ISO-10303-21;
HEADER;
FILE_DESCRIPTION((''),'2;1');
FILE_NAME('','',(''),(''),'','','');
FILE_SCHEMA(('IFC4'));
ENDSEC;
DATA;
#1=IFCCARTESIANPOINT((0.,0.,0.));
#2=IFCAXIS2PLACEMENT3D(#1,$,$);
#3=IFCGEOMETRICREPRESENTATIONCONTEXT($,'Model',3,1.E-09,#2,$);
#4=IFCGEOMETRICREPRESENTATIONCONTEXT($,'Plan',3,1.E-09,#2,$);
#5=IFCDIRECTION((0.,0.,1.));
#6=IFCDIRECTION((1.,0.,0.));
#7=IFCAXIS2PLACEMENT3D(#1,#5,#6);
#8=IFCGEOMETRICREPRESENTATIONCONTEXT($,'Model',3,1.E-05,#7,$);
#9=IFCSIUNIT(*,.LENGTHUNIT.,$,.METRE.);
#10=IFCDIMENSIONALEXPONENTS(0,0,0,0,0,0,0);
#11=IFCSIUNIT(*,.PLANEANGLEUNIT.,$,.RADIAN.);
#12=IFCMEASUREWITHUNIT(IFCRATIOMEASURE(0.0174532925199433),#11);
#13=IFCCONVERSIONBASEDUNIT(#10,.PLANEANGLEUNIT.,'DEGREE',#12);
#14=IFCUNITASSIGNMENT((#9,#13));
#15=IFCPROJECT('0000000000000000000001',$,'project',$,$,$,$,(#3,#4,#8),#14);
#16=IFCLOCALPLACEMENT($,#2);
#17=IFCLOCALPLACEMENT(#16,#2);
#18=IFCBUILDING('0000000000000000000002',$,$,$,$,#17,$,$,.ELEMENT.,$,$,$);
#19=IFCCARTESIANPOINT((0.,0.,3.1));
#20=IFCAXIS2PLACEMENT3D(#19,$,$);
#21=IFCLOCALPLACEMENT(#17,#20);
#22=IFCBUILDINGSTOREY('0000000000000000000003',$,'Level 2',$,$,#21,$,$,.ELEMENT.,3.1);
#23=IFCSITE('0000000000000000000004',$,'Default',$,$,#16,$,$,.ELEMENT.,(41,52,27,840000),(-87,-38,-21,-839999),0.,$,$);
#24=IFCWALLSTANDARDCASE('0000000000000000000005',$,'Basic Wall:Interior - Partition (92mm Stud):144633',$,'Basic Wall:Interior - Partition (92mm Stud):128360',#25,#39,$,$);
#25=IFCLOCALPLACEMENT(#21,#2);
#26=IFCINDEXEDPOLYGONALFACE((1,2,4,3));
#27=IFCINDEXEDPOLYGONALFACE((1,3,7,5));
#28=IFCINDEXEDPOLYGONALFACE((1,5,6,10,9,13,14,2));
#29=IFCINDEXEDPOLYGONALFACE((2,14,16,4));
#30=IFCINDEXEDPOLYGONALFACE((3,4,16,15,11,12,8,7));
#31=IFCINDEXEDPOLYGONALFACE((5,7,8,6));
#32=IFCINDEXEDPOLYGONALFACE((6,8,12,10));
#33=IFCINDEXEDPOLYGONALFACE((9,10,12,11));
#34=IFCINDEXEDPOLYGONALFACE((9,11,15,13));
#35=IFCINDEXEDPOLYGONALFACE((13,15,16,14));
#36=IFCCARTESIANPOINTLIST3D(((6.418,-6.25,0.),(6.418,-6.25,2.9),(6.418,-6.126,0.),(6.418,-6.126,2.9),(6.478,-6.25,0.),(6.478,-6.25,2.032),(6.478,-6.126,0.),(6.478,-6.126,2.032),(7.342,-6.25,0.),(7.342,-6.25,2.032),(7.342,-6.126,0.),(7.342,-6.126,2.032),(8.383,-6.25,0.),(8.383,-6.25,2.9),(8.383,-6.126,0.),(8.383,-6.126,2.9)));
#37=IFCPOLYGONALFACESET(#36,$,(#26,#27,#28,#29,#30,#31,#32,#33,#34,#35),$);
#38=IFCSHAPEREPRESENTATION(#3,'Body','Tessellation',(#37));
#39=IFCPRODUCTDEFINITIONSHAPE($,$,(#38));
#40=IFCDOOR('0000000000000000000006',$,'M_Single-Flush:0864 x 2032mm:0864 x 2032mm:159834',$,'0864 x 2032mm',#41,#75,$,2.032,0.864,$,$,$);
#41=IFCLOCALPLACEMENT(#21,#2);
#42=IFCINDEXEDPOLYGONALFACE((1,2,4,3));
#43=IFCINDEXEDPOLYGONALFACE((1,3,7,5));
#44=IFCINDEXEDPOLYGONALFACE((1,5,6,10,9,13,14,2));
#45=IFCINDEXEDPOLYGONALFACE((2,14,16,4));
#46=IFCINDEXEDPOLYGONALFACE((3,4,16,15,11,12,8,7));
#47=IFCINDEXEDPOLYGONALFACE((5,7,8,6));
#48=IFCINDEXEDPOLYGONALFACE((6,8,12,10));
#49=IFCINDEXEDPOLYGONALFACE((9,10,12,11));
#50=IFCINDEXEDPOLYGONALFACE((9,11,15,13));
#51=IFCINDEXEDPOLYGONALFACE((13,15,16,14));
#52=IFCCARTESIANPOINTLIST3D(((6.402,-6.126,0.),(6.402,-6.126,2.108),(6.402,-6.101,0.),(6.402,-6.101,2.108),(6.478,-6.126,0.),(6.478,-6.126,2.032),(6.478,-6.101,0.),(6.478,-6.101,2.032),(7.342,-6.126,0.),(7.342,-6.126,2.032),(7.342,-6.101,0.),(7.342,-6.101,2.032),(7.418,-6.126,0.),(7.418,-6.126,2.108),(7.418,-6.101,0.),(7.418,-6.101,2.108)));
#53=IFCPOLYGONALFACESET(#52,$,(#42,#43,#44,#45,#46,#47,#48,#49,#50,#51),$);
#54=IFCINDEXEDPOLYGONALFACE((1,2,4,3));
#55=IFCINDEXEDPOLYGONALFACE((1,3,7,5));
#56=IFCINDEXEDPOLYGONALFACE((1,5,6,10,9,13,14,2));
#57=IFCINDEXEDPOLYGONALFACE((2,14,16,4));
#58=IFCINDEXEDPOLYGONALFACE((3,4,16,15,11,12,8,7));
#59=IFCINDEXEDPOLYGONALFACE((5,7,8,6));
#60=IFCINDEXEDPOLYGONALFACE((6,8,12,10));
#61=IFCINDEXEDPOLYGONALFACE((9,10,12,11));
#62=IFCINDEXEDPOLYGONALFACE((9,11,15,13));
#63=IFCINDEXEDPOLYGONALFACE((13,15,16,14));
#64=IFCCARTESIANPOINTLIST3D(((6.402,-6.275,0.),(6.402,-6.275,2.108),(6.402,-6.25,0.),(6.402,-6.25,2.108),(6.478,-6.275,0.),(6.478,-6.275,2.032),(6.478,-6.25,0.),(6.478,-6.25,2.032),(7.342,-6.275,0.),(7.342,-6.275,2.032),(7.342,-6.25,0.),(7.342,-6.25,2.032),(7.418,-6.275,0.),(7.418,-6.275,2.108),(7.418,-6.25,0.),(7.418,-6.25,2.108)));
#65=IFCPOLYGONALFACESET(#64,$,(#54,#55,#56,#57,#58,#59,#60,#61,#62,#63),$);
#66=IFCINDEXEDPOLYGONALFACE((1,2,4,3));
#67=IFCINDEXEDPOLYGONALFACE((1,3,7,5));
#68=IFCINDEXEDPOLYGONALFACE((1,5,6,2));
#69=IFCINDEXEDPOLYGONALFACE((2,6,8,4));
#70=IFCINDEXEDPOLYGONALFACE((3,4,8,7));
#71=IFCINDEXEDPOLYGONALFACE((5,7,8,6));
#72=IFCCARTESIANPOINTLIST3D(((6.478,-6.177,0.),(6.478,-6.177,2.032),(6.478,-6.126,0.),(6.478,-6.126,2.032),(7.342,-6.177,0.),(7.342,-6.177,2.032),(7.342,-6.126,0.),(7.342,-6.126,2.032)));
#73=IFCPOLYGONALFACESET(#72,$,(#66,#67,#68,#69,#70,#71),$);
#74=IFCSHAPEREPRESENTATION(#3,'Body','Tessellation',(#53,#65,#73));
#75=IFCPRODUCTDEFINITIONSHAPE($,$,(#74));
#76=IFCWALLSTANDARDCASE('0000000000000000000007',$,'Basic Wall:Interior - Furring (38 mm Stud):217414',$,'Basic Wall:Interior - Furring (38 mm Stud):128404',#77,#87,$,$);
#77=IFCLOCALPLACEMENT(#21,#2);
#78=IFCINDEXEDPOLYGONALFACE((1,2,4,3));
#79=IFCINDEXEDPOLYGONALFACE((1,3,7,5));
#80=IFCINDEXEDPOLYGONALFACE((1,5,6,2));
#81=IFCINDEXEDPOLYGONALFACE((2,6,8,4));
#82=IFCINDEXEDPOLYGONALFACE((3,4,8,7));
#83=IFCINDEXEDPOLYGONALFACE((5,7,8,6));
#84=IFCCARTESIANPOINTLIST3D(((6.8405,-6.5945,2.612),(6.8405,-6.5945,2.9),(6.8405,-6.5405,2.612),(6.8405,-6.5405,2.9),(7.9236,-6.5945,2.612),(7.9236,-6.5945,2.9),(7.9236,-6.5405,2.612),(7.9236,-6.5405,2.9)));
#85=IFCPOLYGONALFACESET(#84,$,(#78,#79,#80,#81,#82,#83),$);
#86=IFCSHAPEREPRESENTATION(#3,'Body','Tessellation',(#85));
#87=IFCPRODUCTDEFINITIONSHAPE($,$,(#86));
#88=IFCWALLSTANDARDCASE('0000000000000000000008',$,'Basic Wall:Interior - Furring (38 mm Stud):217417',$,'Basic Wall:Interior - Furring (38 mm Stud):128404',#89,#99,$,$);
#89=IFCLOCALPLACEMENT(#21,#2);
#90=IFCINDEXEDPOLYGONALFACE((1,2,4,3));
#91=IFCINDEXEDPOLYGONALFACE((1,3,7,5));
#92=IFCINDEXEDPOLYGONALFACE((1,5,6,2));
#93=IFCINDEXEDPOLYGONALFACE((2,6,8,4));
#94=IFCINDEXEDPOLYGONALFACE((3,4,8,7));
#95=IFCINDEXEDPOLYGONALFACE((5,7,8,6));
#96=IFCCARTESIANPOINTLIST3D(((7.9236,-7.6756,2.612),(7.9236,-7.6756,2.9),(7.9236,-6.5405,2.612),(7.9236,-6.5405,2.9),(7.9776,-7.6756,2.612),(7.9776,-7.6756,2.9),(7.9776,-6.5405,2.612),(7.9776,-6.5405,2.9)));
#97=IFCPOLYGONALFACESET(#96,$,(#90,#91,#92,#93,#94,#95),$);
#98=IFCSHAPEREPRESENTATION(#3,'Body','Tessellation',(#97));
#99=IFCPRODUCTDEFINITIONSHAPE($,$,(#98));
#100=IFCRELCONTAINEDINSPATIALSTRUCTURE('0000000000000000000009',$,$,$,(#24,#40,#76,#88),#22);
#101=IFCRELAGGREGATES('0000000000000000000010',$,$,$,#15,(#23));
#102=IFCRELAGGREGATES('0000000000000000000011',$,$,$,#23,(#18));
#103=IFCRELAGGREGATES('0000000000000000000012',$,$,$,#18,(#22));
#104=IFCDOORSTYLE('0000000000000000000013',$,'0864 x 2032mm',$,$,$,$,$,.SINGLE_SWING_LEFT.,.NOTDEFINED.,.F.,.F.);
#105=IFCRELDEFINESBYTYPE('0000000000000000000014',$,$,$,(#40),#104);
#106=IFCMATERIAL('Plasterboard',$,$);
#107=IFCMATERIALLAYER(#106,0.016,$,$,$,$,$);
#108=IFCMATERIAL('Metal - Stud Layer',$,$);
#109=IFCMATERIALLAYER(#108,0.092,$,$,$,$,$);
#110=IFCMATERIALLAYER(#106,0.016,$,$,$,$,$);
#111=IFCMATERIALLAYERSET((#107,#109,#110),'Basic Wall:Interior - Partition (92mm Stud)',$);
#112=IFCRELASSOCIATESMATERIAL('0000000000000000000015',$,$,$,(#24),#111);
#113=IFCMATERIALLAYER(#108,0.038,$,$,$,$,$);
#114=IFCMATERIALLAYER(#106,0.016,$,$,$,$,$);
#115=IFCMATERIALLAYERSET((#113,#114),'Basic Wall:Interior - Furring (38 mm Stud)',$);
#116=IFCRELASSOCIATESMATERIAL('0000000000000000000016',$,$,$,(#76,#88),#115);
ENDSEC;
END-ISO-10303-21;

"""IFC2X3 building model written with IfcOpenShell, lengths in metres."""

from ifc_helpers import new_model, entity, si_unit, converted_unit, frame, frame_2d, origin, origin_with_axes, origin_2d_with_axis, place, context, project, spatial, polyline, rectangle, outline, extrude, source, transform, mapped, material, layer, layer_set, layer_usage, type_object, type_shapes, element, fill, save


model = new_model("IFC2X3")

# Units and contexts
model_context_1 = context("Model", 3, precision=1e-09, world=origin())
plan_context = context("Plan", 3, precision=1e-09, world=origin())
model_context_2 = context("Model", 3, precision=1e-05, world=origin_with_axes())
ifc_project = project(units=[si_unit("LENGTHUNIT", "METRE"), converted_unit("PLANEANGLEUNIT", "DEGREE", entity("IfcRatioMeasure", 0.0174532925199433), si_unit("PLANEANGLEUNIT", "RADIAN"), dimensions=[0, 0, 0, 0, 0, 0, 0])], contexts=[model_context_1, plan_context, model_context_2])

# Site, building, storey
site_placement = place(None, origin())
site = spatial("IfcSite", under=ifc_project, at=site_placement, Name="Default", CompositionType="ELEMENT", RefLatitude=(41, 52, 27, 840000), RefLongitude=(-87, -38, -21, -839999), RefElevation=0.0)
building_placement = place(site_placement, origin())
building = spatial("IfcBuilding", under=site, at=building_placement, CompositionType="ELEMENT")
storey_placement = place(building_placement, frame((0.0, 0.0, 3.1)))
storey = spatial("IfcBuildingStorey", under=building, at=storey_placement, Name="Level 2", CompositionType="ELEMENT", Elevation=3.1)

# Shared definitions
ifc_material_1 = material(Name="Metal - Stud Layer")
ifc_material_2 = material(Name="Plasterboard")

# Wall, opening, door
ifc_layer_1 = layer(ifc_material_2, 0.016)
ifc_layer_2 = layer(ifc_material_1, 0.092)
ifc_layer_3 = layer(ifc_material_2, 0.016)
ifc_layer_set_1 = layer_set([ifc_layer_1, ifc_layer_2, ifc_layer_3], Name="Basic Wall:Interior - Partition (92mm Stud)")
ifc_layer_usage_1 = layer_usage(ifc_layer_set_1, "AXIS2", "NEGATIVE", 0.062)
wall_1_placement = place(storey_placement, frame((6.418, -6.188, 0.0)))
wall_1 = element("IfcWallStandardCase", 1, at=wall_1_placement, inside=storey, material=ifc_layer_usage_1, Name="Basic Wall:Interior - Partition (92mm Stud):144633", ObjectType="Basic Wall:Interior - Partition (92mm Stud):128360", context=model_context_1, shape_type="SweptSolid", body=[
    extrude(rectangle(XDim=1.965, YDim=0.124, at=frame_2d((0.9825, 0.0), x_axis=(-1.0, 0.0))), origin(), (0.0, 0.0, 1.0), 2.9),
])
opening_1_placement = place(wall_1_placement, frame((0.06, -0.062, 0.0)))
opening_1 = element("IfcOpeningElement", 2, at=opening_1_placement, cuts=wall_1, ObjectType="Opening", context=model_context_1, shape_type="SweptSolid", body=[
    extrude(rectangle(XDim=0.864, YDim=2.032, at=frame_2d((1.016, 0.432), x_axis=(0.0, -1.0))), frame((0.0, 0.0, 0.0), z_axis=(0.0, 1.0, 0.0), x_axis=(0.0, 0.0, 1.0)), (0.0, 0.0, 1.0), 0.124),
])
door_style_1 = type_object("IfcDoorStyle", Name="0864 x 2032mm", ConstructionType="NOTDEFINED", OperationType="SINGLE_SWING_LEFT", ParameterTakesPrecedence=False, Sizeable=False)
shared_shape_1 = source(origin(), model_context_1, "Body", "SweptSolid", [
    extrude(outline(polyline([(-0.508, -1.073), (0.508, -1.073), (0.508, 1.035), (0.432, 1.035), (0.432, -0.997), (-0.432, -0.997), (-0.432, 1.035), (-0.508, 1.035), (-0.508, -1.073)])), frame((0.432, 0.149, 1.035), z_axis=(0.0, -1.0, 0.0), x_axis=(-1.0, 0.0, 0.0)), (0.0, 0.0, 1.0), 0.025),
    extrude(outline(polyline([(-1.073, -0.508), (1.035, -0.508), (1.035, -0.432), (-0.997, -0.432), (-0.997, 0.432), (1.035, 0.432), (1.035, 0.508), (-1.073, 0.508), (-1.073, -0.508)])), frame((0.432, 0.0, 1.035), z_axis=(0.0, -1.0, 0.0), x_axis=(0.0, 0.0, -1.0)), (0.0, 0.0, 1.0), 0.025),
    extrude(rectangle(XDim=0.864, YDim=0.051, at=origin_2d_with_axis()), frame((0.432, 0.0985, 0.0)), (0.0, 0.0, 1.0), 2.032),
])
type_shapes(door_style_1, [shared_shape_1])
door_1_placement = place(opening_1_placement, origin())
door_1 = element("IfcDoor", 3, at=door_1_placement, inside=storey, type_object=door_style_1, Name="M_Single-Flush:0864 x 2032mm:0864 x 2032mm:159834", ObjectType="0864 x 2032mm", OverallHeight=2.032, OverallWidth=0.864, context=model_context_1, shape_type="MappedRepresentation", body=[
    mapped(shared_shape_1, transform((0.0, 0.0, 0.0), scale=1.0)),
])
fill(opening_1, door_1)

# Walls
ifc_layer_4 = layer(ifc_material_1, 0.038)
ifc_layer_5 = layer(ifc_material_2, 0.016)
ifc_layer_set_2 = layer_set([ifc_layer_4, ifc_layer_5], Name="Basic Wall:Interior - Furring (38 mm Stud)")
ifc_layer_usage_2 = layer_usage(ifc_layer_set_2, "AXIS2", "NEGATIVE", 0.027)
wall_2_placement = place(storey_placement, frame((6.8405, -6.5675, 2.612)))
element("IfcWallStandardCase", 4, at=wall_2_placement, inside=storey, material=ifc_layer_usage_2, Name="Basic Wall:Interior - Furring (38 mm Stud):217414", ObjectType="Basic Wall:Interior - Furring (38 mm Stud):128404", context=model_context_1, shape_type="SweptSolid", body=[
    extrude(rectangle(XDim=1.0831, YDim=0.054, at=frame_2d((0.5415, 0.0), x_axis=(-1.0, 0.0))), origin(), (0.0, 0.0, 1.0), 0.288),
])
ifc_layer_usage_3 = layer_usage(ifc_layer_set_2, "AXIS2", "NEGATIVE", 0.027)
wall_3_placement = place(storey_placement, frame((7.9506, -6.5405, 2.612), z_axis=(0.0, 0.0, 1.0), x_axis=(0.0, -1.0, 0.0)))
element("IfcWallStandardCase", 5, at=wall_3_placement, inside=storey, material=ifc_layer_usage_3, Name="Basic Wall:Interior - Furring (38 mm Stud):217417", ObjectType="Basic Wall:Interior - Furring (38 mm Stud):128404", context=model_context_1, shape_type="SweptSolid", body=[
    extrude(rectangle(XDim=1.1351, YDim=0.054, at=frame_2d((0.5675, 0.0), x_axis=(-1.0, 0.0))), origin(), (0.0, 0.0, 1.0), 0.288),
])

save(model, "model.ifc")
